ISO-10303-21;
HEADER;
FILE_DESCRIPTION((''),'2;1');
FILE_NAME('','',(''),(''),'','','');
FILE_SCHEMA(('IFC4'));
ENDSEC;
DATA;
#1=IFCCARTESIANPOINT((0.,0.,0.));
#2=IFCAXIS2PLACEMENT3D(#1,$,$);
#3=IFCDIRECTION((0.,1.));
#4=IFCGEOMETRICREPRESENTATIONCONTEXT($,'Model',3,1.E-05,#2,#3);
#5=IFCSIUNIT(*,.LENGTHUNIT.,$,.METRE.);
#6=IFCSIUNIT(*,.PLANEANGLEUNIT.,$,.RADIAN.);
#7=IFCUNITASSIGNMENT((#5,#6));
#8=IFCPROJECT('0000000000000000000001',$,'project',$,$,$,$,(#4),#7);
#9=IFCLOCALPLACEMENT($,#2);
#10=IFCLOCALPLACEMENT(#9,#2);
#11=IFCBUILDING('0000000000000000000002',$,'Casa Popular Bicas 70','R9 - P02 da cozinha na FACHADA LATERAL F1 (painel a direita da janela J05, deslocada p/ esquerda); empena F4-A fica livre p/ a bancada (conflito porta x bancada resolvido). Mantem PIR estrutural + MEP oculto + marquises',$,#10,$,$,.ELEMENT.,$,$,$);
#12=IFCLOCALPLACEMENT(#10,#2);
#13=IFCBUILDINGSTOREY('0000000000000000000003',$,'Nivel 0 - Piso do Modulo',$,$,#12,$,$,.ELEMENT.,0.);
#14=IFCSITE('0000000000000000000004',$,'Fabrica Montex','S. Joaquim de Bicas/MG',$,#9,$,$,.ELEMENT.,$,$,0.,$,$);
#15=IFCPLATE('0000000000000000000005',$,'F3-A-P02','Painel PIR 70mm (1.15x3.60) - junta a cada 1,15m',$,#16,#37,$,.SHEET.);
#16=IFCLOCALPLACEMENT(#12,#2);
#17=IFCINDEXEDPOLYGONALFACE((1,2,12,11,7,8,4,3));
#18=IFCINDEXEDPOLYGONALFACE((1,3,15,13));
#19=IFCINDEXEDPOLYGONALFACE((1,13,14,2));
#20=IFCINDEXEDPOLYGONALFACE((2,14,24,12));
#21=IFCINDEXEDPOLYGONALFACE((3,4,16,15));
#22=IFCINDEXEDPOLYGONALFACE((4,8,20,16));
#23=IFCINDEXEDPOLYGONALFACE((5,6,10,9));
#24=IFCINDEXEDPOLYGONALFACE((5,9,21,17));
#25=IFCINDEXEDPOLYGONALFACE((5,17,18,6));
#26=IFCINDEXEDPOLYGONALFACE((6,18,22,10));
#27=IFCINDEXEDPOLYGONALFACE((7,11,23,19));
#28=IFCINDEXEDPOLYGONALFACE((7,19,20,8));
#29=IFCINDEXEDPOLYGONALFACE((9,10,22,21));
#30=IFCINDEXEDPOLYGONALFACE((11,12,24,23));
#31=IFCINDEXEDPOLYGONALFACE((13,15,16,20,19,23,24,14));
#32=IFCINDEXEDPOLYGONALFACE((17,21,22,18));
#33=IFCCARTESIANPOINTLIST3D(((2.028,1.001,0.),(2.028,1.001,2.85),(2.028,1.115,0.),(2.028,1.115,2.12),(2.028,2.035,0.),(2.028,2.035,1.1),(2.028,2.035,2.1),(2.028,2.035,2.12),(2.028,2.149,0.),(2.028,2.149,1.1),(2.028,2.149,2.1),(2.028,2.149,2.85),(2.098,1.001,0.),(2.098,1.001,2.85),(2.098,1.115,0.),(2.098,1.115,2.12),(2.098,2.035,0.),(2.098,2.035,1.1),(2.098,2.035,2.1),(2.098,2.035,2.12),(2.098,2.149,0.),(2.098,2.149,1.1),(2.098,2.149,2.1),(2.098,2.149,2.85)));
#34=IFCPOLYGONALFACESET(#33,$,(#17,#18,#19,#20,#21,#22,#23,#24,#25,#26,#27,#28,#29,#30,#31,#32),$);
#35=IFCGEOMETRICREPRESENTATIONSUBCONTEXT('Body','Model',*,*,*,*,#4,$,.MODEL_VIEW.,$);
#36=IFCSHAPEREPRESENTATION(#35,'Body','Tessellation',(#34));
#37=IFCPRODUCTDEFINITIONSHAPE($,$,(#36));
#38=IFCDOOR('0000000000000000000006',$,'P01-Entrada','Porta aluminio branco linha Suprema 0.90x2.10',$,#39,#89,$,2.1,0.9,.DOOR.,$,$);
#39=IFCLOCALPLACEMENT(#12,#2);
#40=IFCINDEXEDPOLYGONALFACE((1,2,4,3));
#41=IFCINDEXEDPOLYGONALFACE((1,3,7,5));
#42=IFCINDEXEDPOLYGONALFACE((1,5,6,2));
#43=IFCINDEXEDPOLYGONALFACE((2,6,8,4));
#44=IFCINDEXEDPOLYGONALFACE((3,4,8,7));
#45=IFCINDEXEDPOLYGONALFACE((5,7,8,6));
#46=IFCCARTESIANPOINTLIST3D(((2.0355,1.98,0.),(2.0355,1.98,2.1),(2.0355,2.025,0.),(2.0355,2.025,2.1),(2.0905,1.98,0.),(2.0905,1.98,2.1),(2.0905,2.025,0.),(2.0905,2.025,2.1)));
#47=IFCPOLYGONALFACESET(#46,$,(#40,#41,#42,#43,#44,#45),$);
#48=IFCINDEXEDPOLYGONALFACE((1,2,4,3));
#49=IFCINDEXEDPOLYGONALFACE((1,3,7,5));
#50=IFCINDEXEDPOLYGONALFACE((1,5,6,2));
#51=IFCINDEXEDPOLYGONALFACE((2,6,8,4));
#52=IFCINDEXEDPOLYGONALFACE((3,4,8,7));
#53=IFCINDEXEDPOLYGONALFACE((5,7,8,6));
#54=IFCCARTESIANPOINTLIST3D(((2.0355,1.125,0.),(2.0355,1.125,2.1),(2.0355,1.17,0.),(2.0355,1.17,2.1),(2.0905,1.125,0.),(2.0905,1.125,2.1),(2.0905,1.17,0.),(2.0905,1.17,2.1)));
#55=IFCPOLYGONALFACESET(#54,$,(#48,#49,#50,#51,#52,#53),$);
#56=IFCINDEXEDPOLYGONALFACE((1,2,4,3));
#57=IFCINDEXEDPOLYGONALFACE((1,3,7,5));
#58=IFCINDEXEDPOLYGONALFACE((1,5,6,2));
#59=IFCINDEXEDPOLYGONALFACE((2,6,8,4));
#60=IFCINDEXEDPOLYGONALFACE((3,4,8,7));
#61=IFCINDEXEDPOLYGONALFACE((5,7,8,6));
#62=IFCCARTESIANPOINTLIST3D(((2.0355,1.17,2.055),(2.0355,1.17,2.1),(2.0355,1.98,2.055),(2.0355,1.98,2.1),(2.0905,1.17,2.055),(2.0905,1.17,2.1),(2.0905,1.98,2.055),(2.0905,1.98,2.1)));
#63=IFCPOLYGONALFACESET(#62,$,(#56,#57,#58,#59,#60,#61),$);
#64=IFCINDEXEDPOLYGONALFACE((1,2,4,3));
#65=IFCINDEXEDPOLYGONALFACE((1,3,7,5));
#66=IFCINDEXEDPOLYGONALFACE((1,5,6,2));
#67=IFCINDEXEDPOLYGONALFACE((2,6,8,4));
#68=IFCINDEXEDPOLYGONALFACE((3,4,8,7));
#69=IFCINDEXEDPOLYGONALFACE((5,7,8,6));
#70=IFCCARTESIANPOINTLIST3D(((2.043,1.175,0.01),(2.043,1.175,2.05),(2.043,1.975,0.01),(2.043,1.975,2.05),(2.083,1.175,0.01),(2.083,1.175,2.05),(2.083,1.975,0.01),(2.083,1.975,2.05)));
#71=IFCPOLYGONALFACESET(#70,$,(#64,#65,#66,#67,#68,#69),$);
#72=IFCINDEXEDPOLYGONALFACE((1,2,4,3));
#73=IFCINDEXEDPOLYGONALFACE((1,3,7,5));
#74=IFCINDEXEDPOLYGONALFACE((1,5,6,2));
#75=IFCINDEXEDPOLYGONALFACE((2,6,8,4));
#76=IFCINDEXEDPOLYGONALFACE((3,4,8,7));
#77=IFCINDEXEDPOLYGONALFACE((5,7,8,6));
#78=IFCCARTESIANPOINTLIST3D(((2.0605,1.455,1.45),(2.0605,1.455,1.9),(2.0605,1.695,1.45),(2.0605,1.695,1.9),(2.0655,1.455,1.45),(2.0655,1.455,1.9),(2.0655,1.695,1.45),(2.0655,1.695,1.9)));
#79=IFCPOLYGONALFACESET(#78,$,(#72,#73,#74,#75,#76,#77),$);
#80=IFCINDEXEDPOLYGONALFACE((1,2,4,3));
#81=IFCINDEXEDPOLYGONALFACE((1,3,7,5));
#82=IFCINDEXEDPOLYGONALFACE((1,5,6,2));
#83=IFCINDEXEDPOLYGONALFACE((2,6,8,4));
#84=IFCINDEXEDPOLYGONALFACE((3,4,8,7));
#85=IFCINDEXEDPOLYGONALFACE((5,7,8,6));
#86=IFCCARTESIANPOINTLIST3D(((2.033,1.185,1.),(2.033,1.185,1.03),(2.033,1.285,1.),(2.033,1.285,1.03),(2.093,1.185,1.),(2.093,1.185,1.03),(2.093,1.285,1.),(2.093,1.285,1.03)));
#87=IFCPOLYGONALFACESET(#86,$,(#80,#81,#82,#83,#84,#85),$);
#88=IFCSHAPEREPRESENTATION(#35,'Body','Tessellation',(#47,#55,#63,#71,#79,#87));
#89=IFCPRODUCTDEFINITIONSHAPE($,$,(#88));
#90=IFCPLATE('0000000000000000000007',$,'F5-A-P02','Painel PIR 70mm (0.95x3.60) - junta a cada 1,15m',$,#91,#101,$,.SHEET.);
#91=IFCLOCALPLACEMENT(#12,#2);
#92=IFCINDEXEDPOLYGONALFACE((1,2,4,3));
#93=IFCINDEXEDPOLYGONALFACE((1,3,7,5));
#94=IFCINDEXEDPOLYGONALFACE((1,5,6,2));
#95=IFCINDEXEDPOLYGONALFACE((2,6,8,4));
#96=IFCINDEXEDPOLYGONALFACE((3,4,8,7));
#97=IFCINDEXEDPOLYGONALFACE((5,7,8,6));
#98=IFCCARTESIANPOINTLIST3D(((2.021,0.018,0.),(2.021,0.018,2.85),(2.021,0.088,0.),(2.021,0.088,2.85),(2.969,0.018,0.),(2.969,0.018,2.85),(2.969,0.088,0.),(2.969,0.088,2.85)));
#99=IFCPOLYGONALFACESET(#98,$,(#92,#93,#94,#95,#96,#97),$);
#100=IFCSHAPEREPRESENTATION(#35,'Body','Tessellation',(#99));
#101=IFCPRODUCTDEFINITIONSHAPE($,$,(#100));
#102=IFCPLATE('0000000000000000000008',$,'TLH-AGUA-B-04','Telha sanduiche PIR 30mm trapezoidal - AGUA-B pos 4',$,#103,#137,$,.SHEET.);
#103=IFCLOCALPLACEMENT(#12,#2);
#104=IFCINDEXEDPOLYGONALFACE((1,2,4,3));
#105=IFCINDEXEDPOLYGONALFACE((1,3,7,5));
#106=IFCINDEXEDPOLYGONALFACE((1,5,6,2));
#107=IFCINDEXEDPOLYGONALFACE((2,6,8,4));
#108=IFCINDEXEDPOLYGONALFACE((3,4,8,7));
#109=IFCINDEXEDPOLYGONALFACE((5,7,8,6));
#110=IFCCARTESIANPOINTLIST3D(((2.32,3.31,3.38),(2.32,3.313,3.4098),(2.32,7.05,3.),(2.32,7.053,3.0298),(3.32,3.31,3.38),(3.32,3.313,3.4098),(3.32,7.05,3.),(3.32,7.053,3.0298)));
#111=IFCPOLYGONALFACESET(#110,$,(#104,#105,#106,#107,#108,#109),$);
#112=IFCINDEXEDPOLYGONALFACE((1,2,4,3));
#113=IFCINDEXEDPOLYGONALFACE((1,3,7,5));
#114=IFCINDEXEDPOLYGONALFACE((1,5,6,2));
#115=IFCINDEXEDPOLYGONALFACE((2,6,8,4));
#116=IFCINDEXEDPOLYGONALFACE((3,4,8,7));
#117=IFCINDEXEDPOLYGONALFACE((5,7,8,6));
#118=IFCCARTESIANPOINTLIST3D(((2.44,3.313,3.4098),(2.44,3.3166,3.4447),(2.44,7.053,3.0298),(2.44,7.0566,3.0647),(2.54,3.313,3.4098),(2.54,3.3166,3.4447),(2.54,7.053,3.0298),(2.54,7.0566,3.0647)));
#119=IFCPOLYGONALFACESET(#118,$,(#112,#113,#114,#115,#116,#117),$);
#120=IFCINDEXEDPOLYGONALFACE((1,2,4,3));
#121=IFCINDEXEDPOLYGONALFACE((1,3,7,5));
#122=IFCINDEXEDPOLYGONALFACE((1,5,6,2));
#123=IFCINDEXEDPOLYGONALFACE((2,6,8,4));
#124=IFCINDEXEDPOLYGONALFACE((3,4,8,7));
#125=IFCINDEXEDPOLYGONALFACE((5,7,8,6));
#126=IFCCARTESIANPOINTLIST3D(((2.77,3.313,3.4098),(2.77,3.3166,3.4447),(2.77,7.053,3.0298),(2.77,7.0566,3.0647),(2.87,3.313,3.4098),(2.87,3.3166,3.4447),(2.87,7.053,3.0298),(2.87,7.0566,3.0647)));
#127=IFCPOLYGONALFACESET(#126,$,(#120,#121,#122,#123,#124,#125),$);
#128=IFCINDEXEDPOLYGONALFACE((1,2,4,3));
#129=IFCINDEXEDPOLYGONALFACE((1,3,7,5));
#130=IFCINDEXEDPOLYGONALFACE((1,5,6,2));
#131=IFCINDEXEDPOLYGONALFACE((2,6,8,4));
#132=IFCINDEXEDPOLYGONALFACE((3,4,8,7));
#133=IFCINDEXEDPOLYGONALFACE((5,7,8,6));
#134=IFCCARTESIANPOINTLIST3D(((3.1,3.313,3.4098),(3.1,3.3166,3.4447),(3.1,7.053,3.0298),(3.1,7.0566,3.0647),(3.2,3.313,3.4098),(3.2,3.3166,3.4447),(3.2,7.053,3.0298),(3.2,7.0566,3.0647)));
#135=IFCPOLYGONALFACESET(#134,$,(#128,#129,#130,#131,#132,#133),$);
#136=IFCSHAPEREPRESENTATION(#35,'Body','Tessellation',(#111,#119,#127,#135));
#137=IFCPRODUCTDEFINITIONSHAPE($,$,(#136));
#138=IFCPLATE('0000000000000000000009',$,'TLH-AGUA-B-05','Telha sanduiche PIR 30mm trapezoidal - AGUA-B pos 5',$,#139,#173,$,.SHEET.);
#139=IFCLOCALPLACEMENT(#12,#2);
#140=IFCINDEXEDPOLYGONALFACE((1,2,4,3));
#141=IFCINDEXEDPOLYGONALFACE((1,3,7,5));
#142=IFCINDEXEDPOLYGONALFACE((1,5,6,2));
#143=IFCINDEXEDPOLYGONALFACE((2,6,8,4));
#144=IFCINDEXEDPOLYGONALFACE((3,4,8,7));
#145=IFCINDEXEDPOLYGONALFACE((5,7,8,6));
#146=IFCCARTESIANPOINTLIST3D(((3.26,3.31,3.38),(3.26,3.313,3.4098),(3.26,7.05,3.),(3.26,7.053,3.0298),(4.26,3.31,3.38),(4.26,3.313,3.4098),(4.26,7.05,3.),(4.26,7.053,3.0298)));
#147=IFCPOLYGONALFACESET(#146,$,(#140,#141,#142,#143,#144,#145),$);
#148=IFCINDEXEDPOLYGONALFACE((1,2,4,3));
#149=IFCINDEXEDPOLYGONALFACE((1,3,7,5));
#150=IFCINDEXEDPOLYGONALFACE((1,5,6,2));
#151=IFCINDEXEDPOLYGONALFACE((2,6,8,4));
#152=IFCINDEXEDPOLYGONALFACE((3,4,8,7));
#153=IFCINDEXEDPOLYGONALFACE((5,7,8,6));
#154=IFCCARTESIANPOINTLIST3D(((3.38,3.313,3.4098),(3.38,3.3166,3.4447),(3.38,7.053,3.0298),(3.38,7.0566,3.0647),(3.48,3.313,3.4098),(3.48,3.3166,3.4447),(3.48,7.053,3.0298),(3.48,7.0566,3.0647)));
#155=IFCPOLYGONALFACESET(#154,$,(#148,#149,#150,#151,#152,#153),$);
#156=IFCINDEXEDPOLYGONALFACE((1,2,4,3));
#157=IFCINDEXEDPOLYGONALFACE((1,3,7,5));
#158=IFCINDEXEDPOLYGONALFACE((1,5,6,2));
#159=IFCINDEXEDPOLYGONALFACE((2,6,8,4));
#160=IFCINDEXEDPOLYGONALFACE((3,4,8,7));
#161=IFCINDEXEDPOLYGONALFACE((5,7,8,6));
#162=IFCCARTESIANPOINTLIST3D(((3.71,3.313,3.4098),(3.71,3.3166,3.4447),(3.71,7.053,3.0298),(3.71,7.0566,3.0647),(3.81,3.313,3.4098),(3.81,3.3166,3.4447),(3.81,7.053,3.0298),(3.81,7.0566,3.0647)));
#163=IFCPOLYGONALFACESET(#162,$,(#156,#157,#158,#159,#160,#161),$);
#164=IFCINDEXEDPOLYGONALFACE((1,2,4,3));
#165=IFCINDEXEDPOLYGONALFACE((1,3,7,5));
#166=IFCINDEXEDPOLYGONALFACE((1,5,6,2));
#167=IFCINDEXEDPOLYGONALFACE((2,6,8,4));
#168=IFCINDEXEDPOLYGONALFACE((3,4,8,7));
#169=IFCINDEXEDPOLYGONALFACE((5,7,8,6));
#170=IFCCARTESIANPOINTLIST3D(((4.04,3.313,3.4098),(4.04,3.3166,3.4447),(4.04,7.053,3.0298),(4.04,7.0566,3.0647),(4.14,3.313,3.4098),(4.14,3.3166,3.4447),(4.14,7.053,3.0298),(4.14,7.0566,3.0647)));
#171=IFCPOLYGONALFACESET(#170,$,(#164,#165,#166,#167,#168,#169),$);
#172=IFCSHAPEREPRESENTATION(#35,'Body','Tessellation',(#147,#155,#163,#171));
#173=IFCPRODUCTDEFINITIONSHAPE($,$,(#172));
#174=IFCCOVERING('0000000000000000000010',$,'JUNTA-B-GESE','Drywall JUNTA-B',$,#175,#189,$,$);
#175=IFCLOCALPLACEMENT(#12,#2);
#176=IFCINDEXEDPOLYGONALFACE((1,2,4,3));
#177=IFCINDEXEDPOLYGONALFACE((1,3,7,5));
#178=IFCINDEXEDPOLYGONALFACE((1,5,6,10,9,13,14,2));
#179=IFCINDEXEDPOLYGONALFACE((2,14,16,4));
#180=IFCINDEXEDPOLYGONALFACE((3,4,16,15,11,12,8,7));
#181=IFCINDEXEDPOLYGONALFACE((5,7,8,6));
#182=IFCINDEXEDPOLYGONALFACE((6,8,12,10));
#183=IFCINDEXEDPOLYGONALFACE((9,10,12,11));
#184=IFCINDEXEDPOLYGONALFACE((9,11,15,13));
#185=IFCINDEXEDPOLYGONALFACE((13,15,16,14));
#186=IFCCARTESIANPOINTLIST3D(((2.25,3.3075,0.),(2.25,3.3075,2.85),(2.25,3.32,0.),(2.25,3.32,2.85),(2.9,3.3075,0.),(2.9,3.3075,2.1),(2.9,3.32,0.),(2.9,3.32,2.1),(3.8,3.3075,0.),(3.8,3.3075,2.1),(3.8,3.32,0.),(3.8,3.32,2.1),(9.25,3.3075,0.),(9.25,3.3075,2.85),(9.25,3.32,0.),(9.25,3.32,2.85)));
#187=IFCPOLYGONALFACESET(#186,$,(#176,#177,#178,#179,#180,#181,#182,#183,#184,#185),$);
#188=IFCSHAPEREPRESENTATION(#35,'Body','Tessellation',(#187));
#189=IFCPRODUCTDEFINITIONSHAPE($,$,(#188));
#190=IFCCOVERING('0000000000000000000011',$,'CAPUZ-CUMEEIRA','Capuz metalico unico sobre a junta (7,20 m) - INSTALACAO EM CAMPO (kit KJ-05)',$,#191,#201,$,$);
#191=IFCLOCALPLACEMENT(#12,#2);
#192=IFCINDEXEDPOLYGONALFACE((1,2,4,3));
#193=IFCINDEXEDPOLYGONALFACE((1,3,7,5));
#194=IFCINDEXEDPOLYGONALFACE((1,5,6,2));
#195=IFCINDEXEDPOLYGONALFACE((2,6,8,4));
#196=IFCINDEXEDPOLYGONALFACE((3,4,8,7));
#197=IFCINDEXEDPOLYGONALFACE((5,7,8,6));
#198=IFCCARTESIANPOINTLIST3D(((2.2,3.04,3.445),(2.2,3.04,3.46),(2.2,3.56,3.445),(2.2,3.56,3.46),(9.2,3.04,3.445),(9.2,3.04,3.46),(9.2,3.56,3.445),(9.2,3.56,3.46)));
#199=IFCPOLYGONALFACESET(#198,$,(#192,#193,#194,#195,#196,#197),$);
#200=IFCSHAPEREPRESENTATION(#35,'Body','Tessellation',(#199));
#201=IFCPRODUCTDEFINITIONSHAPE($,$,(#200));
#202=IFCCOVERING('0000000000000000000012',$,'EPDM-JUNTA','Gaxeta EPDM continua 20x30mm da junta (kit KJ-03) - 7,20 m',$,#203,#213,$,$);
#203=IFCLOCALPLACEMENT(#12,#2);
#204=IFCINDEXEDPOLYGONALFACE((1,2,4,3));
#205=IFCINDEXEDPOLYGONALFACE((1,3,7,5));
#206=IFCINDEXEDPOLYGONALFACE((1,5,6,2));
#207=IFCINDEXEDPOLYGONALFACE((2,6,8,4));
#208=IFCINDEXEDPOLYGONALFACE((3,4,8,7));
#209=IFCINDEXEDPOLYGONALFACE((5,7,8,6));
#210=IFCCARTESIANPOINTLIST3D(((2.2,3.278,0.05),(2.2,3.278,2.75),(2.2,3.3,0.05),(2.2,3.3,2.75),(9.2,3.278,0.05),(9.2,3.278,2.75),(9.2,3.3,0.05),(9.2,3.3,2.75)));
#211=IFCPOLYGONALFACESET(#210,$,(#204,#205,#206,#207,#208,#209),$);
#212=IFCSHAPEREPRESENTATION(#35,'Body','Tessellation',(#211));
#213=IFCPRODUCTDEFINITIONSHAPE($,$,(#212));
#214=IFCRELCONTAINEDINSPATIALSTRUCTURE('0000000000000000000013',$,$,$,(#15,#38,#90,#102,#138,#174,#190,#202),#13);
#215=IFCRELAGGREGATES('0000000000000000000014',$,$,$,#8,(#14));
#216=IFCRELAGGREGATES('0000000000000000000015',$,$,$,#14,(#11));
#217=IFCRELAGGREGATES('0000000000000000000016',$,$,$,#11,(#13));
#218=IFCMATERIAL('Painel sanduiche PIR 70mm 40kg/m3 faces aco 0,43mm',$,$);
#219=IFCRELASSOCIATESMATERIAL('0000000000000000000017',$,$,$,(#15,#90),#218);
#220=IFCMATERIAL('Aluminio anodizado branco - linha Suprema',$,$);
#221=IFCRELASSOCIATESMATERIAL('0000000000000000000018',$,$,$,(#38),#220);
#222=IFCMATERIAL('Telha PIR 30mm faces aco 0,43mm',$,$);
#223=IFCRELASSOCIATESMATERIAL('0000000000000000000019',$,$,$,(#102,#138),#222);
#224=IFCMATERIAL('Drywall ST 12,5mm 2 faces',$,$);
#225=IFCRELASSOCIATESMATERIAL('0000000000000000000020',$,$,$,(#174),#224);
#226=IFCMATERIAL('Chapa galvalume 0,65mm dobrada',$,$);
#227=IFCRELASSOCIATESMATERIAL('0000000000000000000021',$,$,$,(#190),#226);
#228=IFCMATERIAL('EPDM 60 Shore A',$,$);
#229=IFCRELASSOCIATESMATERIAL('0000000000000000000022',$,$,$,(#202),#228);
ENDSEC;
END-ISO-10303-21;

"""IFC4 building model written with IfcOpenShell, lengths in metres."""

from ifc_helpers import new_model, si_unit, direction, frame, frame_2d, origin, origin_2d, place, context, subcontext, project, spatial, rectangle, extrude, material, element, fill, save


model = new_model("IFC4")

# Units and contexts
model_context = context("Model", 3, precision=1e-05, world=origin(), true_north=direction((0.0, 1.0)))
body_context = subcontext(model_context, "Body", "Model", "MODEL_VIEW")
ifc_project = project(units=[si_unit("LENGTHUNIT", "METRE"), si_unit("PLANEANGLEUNIT", "RADIAN")], contexts=[model_context])

# Site, building, storey
site_placement = place(None, origin())
site = spatial("IfcSite", under=ifc_project, at=site_placement, Name="Fabrica Montex", Description="S. Joaquim de Bicas/MG", CompositionType="ELEMENT", RefElevation=0.0)
building_placement = place(site_placement, origin())
building = spatial("IfcBuilding", under=site, at=building_placement, Name="Casa Popular Bicas 70", Description="R9 - P02 da cozinha na FACHADA LATERAL F1 (painel a direita da janela J05, deslocada p/ esquerda); empena F4-A fica livre p/ a bancada (conflito porta x bancada resolvido). Mantem PIR estrutural + MEP oculto + marquises", CompositionType="ELEMENT")
storey_placement = place(building_placement, origin())
storey = spatial("IfcBuildingStorey", under=building, at=storey_placement, Name="Nivel 0 - Piso do Modulo", CompositionType="ELEMENT", Elevation=0.0)

# Shared definitions
ifc_material_1 = material(Name="Painel sanduiche PIR 70mm 40kg/m3 faces aco 0,43mm")

# Plate, openings, door
plate_1_placement = place(None, frame((2.063, 2.149, 0.0), z_axis=(0.0, 0.0, 1.0), x_axis=(0.0, -1.0, 0.0)))
plate_1 = element("IfcPlate", 1, at=plate_1_placement, inside=storey, material=ifc_material_1, Name="F3-A-P02", Description="Painel PIR 70mm (1.15x3.60) - junta a cada 1,15m", PredefinedType="SHEET", context=body_context, shape_type="SweptSolid", body=[
    extrude(rectangle(XDim=1.148, YDim=0.07, at=frame_2d((0.574, 0.0))), origin(), (0.0, 0.0, 1.0), 2.85),
])
opening_1_placement = place(None, frame((2.063, 1.95, 1.1), z_axis=(0.0, 0.0, 1.0), x_axis=(-1.0, 0.0, 0.0)))
element("IfcOpeningElement", 2, at=opening_1_placement, cuts=plate_1, PredefinedType="OPENING", context=body_context, shape_type="SweptSolid", body=[
    extrude(rectangle(XDim=0.1, YDim=0.4, at=origin_2d()), origin(), (0.0, 0.0, 1.0), 1.0),
])
opening_2_placement = place(None, frame((2.063, 2.025, 0.0), z_axis=(0.0, 0.0, 1.0), x_axis=(0.0, -1.0, 0.0)))
opening_2 = element("IfcOpeningElement", 3, at=opening_2_placement, cuts=plate_1, PredefinedType="OPENING", context=body_context, shape_type="SweptSolid", body=[
    extrude(rectangle(XDim=0.92, YDim=0.3, at=frame_2d((0.45, 0.0))), origin(), (0.0, 0.0, 1.0), 2.12),
])
ifc_material_2 = material(Name="Aluminio anodizado branco - linha Suprema")
door_placement = place(None, frame((2.063, 2.025, 0.0), z_axis=(0.0, 0.0, 1.0), x_axis=(0.0, -1.0, 0.0)))
door = element("IfcDoor", 4, at=door_placement, inside=storey, material=ifc_material_2, Name="P01-Entrada", Description="Porta aluminio branco linha Suprema 0.90x2.10", OverallHeight=2.1, OverallWidth=0.9, PredefinedType="DOOR", context=body_context, shape_type="SweptSolid", body=[
    extrude(rectangle(XDim=0.045, YDim=0.055, at=frame_2d((0.0225, 0.0))), origin(), (0.0, 0.0, 1.0), 2.1),
    extrude(rectangle(XDim=0.045, YDim=0.055, at=frame_2d((0.8775, 0.0))), origin(), (0.0, 0.0, 1.0), 2.1),
    extrude(rectangle(XDim=0.81, YDim=0.055, at=frame_2d((0.45, 0.0))), frame((0.0, 0.0, 2.055)), (0.0, 0.0, 1.0), 0.045),
    extrude(rectangle(XDim=0.8, YDim=0.04, at=frame_2d((0.45, 0.0))), frame((0.0, 0.0, 0.01)), (0.0, 0.0, 1.0), 2.04),
    extrude(rectangle(XDim=0.24, YDim=0.005, at=frame_2d((0.45, 0.0))), frame((0.0, 0.0, 1.45)), (0.0, 0.0, 1.0), 0.45),
    extrude(rectangle(XDim=0.1, YDim=0.06, at=frame_2d((0.79, 0.0))), frame((0.0, 0.0, 1.0)), (0.0, 0.0, 1.0), 0.03),
])
fill(opening_2, door)

# Plates
plate_2_placement = place(None, frame((2.969, 0.053, 0.0), z_axis=(0.0, 0.0, 1.0), x_axis=(-1.0, 0.0, 0.0)))
element("IfcPlate", 5, at=plate_2_placement, inside=storey, material=ifc_material_1, Name="F5-A-P02", Description="Painel PIR 70mm (0.95x3.60) - junta a cada 1,15m", PredefinedType="SHEET", context=body_context, shape_type="SweptSolid", body=[
    extrude(rectangle(XDim=0.948, YDim=0.07, at=frame_2d((0.474, 0.0))), origin(), (0.0, 0.0, 1.0), 2.85),
])
ifc_material_3 = material(Name="Telha PIR 30mm faces aco 0,43mm")
for number, where, z_axis, x_axis, name, description in (
    (6, (2.32, 3.31, 3.38), (0.0, 0.101084, 0.994878), (1.0, 0.0, 0.0), "TLH-AGUA-B-04", "Telha sanduiche PIR 30mm trapezoidal - AGUA-B pos 4"),
    (7, (3.26, 3.31, 3.38), (0.0, 0.101084, 0.994878), (1.0, 0.0, 0.0), "TLH-AGUA-B-05", "Telha sanduiche PIR 30mm trapezoidal - AGUA-B pos 5"),
):
    element("IfcPlate", number, at=place(storey_placement, frame(where, z_axis=z_axis, x_axis=x_axis)), inside=storey, material=ifc_material_3, Name=name, Description=description, PredefinedType="SHEET", context=body_context, shape_type="SweptSolid", body=[
        extrude(rectangle(XDim=1.0, YDim=3.7593, at=frame_2d((0.5, 1.8796))), origin(), (0.0, 0.0, 1.0), 0.03),
        extrude(rectangle(XDim=0.1, YDim=3.7593, at=frame_2d((0.17, 1.8796))), frame((0.0, 0.0, 0.03)), (0.0, 0.0, 1.0), 0.035),
        extrude(rectangle(XDim=0.1, YDim=3.7593, at=frame_2d((0.5, 1.8796))), frame((0.0, 0.0, 0.03)), (0.0, 0.0, 1.0), 0.035),
        extrude(rectangle(XDim=0.1, YDim=3.7593, at=frame_2d((0.83, 1.8796))), frame((0.0, 0.0, 0.03)), (0.0, 0.0, 1.0), 0.035),
    ])

# Covering, opening
ifc_material_4 = material(Name="Drywall ST 12,5mm 2 faces")
covering_1_placement = place(storey_placement, frame((2.25, 3.3137, 0.0), x_axis=(1.0, 0.0, 0.0)))
covering_1 = element("IfcCovering", 8, at=covering_1_placement, inside=storey, material=ifc_material_4, Name="JUNTA-B-GESE", Description="Drywall JUNTA-B", context=body_context, shape_type="SweptSolid", body=[
    extrude(rectangle(XDim=7.0, YDim=0.0125, at=frame_2d((3.5, 0.0))), origin(), (0.0, 0.0, 1.0), 2.85),
])
opening_3_placement = place(storey_placement, frame((3.35, 3.3137, 0.0)))
element("IfcOpeningElement", 9, at=opening_3_placement, cuts=covering_1, PredefinedType="OPENING", context=body_context, shape_type="SweptSolid", body=[
    extrude(rectangle(XDim=0.9, YDim=0.0425, at=origin_2d()), origin(), (0.0, 0.0, 1.0), 2.1),
])

# Coverings
ifc_material_5 = material(Name="Chapa galvalume 0,65mm dobrada")
covering_2_placement = place(storey_placement, frame((2.2, 3.04, 3.445), x_axis=(1.0, 0.0, 0.0)))
element("IfcCovering", 10, at=covering_2_placement, inside=storey, material=ifc_material_5, Name="CAPUZ-CUMEEIRA", Description="Capuz metalico unico sobre a junta (7,20 m) - INSTALACAO EM CAMPO (kit KJ-05)", context=body_context, shape_type="SweptSolid", body=[
    extrude(rectangle(XDim=7.0, YDim=0.52, at=frame_2d((3.5, 0.26))), origin(), (0.0, 0.0, 1.0), 0.015),
])
ifc_material_6 = material(Name="EPDM 60 Shore A")
covering_3_placement = place(storey_placement, frame((2.2, 3.289, 0.05), x_axis=(1.0, 0.0, 0.0)))
element("IfcCovering", 11, at=covering_3_placement, inside=storey, material=ifc_material_6, Name="EPDM-JUNTA", Description="Gaxeta EPDM continua 20x30mm da junta (kit KJ-03) - 7,20 m", context=body_context, shape_type="SweptSolid", body=[
    extrude(rectangle(XDim=7.0, YDim=0.022, at=frame_2d((3.5, 0.0))), origin(), (0.0, 0.0, 1.0), 2.7),
])

save(model, "model.ifc")
